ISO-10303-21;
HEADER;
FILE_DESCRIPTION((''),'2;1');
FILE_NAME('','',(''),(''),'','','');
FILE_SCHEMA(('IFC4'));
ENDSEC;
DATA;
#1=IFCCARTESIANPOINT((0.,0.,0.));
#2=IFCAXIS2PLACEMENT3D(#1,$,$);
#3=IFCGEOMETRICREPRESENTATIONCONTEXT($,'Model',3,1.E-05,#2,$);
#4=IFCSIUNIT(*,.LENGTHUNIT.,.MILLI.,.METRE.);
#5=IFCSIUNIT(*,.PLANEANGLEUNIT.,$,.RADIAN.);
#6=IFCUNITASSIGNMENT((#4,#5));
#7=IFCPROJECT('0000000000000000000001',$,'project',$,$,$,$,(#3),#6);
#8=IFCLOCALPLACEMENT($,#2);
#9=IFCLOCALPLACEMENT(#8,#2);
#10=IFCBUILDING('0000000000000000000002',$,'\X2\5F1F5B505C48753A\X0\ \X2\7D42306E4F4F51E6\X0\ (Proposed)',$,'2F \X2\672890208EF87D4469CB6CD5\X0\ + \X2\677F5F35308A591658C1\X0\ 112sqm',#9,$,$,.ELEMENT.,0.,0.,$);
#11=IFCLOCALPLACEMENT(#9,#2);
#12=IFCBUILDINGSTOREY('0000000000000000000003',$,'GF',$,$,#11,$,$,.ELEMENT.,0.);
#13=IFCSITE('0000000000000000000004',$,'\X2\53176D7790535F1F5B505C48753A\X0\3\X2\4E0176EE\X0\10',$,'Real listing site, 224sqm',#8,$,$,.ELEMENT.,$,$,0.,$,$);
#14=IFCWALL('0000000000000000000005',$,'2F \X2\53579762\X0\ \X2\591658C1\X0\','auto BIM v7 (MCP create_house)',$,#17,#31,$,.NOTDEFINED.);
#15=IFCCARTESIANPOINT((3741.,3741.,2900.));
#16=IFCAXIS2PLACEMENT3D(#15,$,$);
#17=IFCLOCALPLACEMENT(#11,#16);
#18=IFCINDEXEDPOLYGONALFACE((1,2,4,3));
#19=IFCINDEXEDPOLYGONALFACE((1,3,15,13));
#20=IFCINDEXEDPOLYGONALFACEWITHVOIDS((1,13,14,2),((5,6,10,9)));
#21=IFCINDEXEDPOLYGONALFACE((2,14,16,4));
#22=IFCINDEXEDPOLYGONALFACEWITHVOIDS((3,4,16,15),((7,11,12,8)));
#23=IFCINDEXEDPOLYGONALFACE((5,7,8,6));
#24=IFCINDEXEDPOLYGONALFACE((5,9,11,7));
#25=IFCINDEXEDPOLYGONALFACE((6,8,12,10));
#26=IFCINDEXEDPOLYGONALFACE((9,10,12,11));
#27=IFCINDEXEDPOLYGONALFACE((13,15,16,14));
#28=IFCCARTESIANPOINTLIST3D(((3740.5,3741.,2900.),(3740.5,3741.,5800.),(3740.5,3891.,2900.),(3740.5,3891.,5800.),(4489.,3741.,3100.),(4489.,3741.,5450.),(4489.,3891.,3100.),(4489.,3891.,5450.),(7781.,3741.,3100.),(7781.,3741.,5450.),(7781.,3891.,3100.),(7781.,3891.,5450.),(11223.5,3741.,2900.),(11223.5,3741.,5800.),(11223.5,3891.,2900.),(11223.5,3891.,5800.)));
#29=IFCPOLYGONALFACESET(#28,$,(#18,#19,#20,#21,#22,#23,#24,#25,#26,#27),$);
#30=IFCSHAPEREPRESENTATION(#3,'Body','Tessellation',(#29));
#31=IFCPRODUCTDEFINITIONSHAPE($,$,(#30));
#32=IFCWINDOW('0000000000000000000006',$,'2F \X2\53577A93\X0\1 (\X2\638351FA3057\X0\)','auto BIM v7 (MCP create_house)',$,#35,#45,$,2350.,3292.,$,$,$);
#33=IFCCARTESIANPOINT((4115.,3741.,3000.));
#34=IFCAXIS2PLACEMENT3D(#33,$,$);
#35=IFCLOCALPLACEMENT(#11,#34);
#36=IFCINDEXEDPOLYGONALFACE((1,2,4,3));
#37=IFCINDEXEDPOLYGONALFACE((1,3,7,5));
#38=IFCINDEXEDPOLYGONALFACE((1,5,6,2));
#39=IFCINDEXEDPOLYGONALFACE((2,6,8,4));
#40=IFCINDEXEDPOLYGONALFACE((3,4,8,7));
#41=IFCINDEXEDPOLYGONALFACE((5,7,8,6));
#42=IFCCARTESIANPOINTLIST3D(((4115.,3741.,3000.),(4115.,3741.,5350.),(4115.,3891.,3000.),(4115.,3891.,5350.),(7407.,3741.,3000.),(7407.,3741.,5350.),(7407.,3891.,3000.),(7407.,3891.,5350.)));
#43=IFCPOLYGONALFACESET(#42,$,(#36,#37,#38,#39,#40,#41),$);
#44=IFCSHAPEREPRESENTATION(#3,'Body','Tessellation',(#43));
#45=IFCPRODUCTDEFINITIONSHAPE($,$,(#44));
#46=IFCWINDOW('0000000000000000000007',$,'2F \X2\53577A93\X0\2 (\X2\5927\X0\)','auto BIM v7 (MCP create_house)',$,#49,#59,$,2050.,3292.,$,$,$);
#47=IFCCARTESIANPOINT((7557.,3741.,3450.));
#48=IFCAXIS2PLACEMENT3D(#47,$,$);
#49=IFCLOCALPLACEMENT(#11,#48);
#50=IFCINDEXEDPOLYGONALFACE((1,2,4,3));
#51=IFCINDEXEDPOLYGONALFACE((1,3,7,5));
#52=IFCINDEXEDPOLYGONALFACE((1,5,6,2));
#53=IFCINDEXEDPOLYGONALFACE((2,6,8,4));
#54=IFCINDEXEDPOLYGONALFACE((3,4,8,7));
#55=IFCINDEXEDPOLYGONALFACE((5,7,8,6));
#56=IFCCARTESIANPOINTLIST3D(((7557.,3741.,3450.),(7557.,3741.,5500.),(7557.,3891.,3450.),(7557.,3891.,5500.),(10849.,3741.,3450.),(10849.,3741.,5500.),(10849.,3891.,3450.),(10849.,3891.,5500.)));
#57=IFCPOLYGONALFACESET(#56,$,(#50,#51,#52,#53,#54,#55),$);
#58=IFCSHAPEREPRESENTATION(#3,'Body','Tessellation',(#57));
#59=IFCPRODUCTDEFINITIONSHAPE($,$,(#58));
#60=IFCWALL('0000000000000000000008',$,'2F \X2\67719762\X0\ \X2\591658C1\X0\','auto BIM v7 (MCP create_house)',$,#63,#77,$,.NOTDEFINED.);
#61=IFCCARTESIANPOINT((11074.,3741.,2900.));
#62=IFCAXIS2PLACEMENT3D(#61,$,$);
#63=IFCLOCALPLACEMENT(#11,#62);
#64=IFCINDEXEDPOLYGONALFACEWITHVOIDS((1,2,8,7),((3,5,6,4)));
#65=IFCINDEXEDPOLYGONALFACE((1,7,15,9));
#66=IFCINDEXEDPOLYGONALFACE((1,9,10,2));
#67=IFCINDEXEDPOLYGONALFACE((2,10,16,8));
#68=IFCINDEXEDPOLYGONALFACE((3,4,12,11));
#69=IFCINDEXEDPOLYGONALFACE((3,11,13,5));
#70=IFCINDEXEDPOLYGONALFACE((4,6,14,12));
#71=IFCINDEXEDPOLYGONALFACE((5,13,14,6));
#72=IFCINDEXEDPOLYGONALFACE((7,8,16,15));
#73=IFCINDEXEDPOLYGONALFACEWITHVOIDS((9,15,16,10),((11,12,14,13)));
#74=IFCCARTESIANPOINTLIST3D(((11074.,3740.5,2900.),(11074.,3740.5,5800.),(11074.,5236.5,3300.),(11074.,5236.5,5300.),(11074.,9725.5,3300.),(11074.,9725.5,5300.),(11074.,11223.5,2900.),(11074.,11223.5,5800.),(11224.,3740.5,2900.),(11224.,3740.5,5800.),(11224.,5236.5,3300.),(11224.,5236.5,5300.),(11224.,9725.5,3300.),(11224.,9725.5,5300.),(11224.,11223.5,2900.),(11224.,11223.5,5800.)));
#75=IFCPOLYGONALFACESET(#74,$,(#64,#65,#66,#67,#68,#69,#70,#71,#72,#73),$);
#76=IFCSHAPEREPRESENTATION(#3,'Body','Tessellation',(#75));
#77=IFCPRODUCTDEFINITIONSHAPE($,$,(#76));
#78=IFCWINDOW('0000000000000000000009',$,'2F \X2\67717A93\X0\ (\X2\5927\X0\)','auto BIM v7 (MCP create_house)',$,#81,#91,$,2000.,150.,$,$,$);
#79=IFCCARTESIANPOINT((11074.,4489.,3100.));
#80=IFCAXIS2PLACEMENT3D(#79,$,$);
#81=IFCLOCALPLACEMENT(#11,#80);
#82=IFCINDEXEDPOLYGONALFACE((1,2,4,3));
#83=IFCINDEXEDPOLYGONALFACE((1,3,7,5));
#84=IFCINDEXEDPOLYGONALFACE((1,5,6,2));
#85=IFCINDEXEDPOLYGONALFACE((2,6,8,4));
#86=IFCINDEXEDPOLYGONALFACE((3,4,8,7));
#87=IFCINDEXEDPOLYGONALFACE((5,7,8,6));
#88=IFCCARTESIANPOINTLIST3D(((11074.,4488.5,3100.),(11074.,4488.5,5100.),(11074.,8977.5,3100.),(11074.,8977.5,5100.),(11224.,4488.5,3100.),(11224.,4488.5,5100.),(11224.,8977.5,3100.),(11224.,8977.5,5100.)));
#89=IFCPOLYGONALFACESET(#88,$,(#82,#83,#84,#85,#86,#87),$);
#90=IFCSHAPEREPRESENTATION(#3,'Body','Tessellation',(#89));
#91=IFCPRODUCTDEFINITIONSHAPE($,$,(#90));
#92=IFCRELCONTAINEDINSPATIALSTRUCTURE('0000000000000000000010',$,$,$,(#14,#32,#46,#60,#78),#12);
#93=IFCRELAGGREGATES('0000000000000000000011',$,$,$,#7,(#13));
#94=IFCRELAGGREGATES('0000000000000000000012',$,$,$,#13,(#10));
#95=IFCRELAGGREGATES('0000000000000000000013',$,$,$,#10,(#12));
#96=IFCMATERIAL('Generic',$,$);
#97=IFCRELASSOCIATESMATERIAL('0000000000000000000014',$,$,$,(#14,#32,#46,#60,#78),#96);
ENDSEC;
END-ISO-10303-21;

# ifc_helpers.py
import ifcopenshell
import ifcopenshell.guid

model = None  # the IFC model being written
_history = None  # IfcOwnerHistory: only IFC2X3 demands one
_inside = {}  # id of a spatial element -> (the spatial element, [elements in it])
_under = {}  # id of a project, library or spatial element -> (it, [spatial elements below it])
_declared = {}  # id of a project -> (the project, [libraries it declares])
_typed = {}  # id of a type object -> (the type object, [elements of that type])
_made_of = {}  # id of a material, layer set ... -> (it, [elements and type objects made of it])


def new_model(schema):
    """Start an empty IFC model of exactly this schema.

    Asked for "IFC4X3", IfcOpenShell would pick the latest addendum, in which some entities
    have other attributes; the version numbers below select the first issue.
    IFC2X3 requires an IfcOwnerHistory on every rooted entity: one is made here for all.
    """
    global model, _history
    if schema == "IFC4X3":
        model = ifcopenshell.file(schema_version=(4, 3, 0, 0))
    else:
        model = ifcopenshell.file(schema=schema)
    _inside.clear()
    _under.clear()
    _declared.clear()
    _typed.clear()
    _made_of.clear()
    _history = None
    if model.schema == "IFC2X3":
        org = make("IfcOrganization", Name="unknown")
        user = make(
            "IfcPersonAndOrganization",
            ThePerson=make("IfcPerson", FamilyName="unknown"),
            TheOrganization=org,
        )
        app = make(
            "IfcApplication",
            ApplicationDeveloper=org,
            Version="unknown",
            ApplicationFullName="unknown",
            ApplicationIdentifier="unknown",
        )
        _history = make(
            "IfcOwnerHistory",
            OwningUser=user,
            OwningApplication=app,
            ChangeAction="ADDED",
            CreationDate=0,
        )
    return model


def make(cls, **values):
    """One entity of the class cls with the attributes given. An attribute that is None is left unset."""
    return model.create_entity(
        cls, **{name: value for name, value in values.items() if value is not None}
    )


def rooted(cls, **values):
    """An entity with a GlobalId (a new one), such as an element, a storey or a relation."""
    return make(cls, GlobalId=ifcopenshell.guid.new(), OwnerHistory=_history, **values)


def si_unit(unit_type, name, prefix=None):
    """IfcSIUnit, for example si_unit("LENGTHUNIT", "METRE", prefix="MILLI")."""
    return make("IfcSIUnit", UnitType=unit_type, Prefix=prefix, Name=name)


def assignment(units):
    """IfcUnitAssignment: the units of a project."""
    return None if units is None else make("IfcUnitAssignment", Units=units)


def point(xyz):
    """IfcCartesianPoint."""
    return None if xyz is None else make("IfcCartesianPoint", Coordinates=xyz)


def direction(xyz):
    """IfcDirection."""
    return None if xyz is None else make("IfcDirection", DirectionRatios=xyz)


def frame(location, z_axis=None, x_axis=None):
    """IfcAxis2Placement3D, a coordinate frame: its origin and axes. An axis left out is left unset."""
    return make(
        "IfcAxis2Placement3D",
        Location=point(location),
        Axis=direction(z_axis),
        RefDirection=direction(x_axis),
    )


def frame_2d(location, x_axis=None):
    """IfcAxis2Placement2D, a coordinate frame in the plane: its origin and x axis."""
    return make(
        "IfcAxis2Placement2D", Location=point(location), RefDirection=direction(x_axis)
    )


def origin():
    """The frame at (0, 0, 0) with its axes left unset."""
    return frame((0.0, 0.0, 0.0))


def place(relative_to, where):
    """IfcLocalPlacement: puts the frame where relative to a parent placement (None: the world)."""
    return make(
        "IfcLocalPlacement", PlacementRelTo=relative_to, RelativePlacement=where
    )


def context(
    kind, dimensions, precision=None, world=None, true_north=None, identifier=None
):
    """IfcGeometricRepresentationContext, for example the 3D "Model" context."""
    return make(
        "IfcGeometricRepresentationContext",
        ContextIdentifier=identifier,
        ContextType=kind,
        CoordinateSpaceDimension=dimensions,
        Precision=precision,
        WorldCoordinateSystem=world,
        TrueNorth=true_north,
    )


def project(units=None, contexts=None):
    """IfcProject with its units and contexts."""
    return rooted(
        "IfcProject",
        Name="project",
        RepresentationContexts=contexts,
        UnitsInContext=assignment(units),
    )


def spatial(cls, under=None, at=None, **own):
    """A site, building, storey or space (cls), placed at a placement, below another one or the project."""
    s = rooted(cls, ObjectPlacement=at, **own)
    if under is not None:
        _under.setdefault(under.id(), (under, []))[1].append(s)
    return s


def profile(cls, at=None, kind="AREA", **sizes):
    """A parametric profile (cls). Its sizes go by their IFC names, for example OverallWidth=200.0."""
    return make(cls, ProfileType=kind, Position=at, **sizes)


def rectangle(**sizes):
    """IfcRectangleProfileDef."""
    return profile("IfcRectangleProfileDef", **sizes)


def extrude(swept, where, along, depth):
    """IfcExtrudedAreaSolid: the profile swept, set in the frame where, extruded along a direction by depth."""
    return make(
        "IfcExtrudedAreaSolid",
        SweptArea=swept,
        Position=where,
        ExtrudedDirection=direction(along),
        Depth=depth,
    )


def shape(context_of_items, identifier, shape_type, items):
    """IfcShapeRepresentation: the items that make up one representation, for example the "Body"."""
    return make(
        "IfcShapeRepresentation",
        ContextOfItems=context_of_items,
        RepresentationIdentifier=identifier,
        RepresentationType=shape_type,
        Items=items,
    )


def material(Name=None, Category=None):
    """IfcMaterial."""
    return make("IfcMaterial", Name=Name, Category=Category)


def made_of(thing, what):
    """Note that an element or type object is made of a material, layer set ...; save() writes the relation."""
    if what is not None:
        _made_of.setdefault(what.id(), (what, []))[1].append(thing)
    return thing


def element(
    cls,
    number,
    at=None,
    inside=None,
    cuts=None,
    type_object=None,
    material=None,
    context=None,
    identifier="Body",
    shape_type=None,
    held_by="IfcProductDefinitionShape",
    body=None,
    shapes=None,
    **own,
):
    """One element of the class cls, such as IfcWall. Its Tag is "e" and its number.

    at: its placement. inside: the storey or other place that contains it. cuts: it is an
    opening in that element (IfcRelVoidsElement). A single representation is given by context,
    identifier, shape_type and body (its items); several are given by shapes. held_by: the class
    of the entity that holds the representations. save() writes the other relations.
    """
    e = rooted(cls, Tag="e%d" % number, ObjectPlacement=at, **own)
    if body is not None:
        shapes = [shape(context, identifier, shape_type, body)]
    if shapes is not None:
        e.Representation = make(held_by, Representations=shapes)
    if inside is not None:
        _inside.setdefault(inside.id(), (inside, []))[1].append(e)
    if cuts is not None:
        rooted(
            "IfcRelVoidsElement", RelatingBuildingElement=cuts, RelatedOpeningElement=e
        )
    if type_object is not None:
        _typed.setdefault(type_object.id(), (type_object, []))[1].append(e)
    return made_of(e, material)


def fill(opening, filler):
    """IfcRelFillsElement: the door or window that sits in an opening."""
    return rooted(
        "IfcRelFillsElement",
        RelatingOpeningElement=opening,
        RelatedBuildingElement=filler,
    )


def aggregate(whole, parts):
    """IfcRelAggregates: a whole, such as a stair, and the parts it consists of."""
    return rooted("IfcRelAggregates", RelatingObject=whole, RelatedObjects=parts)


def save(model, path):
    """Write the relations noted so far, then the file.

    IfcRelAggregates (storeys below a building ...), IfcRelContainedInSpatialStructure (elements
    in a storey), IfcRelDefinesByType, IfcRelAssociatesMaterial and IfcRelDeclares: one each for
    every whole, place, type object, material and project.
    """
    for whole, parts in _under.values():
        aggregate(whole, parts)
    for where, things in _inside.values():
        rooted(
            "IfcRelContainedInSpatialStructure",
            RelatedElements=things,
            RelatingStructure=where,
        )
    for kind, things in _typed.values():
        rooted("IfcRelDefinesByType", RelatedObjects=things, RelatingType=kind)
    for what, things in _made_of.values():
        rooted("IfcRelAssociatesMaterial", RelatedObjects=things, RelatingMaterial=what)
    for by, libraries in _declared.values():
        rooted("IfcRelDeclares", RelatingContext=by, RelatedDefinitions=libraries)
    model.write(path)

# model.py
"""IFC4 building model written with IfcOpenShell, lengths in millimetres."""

from ifc_helpers import new_model, si_unit, frame, frame_2d, origin, place, context, project, spatial, rectangle, extrude, material, element, fill, save


model = new_model("IFC4")

# Units and contexts
model_context = context("Model", 3, precision=1e-05, world=origin())
ifc_project = project(units=[si_unit("LENGTHUNIT", "METRE", prefix="MILLI"), si_unit("PLANEANGLEUNIT", "RADIAN")], contexts=[model_context])

# Site, building, storey
site_placement = place(None, origin())
site = spatial("IfcSite", under=ifc_project, at=site_placement, Name="北海道弟子屈町3丁目10", ObjectType="Real listing site, 224sqm", CompositionType="ELEMENT", RefElevation=0.0)
building_placement = place(site_placement, origin())
building = spatial("IfcBuilding", under=site, at=building_placement, Name="弟子屈町 終の住処 (Proposed)", ObjectType="2F 木造軸組構法 + 板張り外壁 112sqm", CompositionType="ELEMENT", ElevationOfRefHeight=0.0, ElevationOfTerrain=0.0)
storey_placement = place(building_placement, origin())
storey = spatial("IfcBuildingStorey", under=building, at=storey_placement, Name="GF", CompositionType="ELEMENT", Elevation=0.0)

# Shared definitions
ifc_material = material(Name="Generic")

# Wall, openings, windows
wall_1_placement = place(storey_placement, frame((3741.0, 3741.0, 2900.0)))
wall_1 = element("IfcWall", 1, at=wall_1_placement, inside=storey, material=ifc_material, Name="2F 南面 外壁", Description="auto BIM v7 (MCP create_house)", PredefinedType="NOTDEFINED", context=model_context, shape_type="SweptSolid", body=[
    extrude(rectangle(XDim=7483.0, YDim=150.0, at=frame_2d((3741.0, 75.0))), frame((3741.0, 3741.0, 2900.0)), (0.0, 0.0, 1.0), 2900.0),
])
opening_1_placement = place(storey_placement, frame((4115.0, 3741.0, 3000.0)))
opening_1 = element("IfcOpeningElement", 2, at=opening_1_placement, cuts=wall_1, PredefinedType="NOTDEFINED", context=model_context, shape_type="SweptSolid", body=[
    extrude(rectangle(XDim=3292.0, YDim=150.0, at=frame_2d((1646.0, 75.0))), frame((4115.0, 3741.0, 3000.0)), (0.0, 0.0, 1.0), 2350.0),
])
opening_2_placement = place(storey_placement, frame((7557.0, 3741.0, 3450.0)))
opening_2 = element("IfcOpeningElement", 3, at=opening_2_placement, cuts=wall_1, PredefinedType="NOTDEFINED", context=model_context, shape_type="SweptSolid", body=[
    extrude(rectangle(XDim=3292.0, YDim=150.0, at=frame_2d((1646.0, 75.0))), frame((7557.0, 3741.0, 3450.0)), (0.0, 0.0, 1.0), 2050.0),
])
window_1_placement = place(storey_placement, frame((4115.0, 3741.0, 3000.0)))
window_1 = element("IfcWindow", 4, at=window_1_placement, inside=storey, material=ifc_material, Name="2F 南窓1 (掃出し)", Description="auto BIM v7 (MCP create_house)", OverallHeight=2350.0, OverallWidth=3292.0, context=model_context, shape_type="SweptSolid", body=[
    extrude(rectangle(XDim=3292.0, YDim=150.0, at=frame_2d((1646.0, 75.0))), frame((4115.0, 3741.0, 3000.0)), (0.0, 0.0, 1.0), 2350.0),
])
fill(opening_1, window_1)
window_2_placement = place(storey_placement, frame((7557.0, 3741.0, 3450.0)))
window_2 = element("IfcWindow", 5, at=window_2_placement, inside=storey, material=ifc_material, Name="2F 南窓2 (大)", Description="auto BIM v7 (MCP create_house)", OverallHeight=2050.0, OverallWidth=3292.0, context=model_context, shape_type="SweptSolid", body=[
    extrude(rectangle(XDim=3292.0, YDim=150.0, at=frame_2d((1646.0, 75.0))), frame((7557.0, 3741.0, 3450.0)), (0.0, 0.0, 1.0), 2050.0),
])
fill(opening_2, window_2)

# Wall, opening, window
wall_2_placement = place(storey_placement, frame((11074.0, 3741.0, 2900.0)))
wall_2 = element("IfcWall", 6, at=wall_2_placement, inside=storey, material=ifc_material, Name="2F 東面 外壁", Description="auto BIM v7 (MCP create_house)", PredefinedType="NOTDEFINED", context=model_context, shape_type="SweptSolid", body=[
    extrude(rectangle(XDim=150.0, YDim=7483.0, at=frame_2d((75.0, 3741.0))), frame((11074.0, 3741.0, 2900.0)), (0.0, 0.0, 1.0), 2900.0),
])
opening_3_placement = place(storey_placement, frame((11074.0, 4489.0, 3100.0)))
opening_3 = element("IfcOpeningElement", 7, at=opening_3_placement, cuts=wall_2, PredefinedType="NOTDEFINED", context=model_context, shape_type="SweptSolid", body=[
    extrude(rectangle(XDim=150.0, YDim=4489.0, at=frame_2d((75.0, 2244.0))), frame((11074.0, 4489.0, 3100.0)), (0.0, 0.0, 1.0), 2000.0),
])
window_3_placement = place(storey_placement, frame((11074.0, 4489.0, 3100.0)))
window_3 = element("IfcWindow", 8, at=window_3_placement, inside=storey, material=ifc_material, Name="2F 東窓 (大)", Description="auto BIM v7 (MCP create_house)", OverallHeight=2000.0, OverallWidth=150.0, context=model_context, shape_type="SweptSolid", body=[
    extrude(rectangle(XDim=150.0, YDim=4489.0, at=frame_2d((75.0, 2244.0))), frame((11074.0, 4489.0, 3100.0)), (0.0, 0.0, 1.0), 2000.0),
])
fill(opening_3, window_3)

save(model, "model.ifc")
